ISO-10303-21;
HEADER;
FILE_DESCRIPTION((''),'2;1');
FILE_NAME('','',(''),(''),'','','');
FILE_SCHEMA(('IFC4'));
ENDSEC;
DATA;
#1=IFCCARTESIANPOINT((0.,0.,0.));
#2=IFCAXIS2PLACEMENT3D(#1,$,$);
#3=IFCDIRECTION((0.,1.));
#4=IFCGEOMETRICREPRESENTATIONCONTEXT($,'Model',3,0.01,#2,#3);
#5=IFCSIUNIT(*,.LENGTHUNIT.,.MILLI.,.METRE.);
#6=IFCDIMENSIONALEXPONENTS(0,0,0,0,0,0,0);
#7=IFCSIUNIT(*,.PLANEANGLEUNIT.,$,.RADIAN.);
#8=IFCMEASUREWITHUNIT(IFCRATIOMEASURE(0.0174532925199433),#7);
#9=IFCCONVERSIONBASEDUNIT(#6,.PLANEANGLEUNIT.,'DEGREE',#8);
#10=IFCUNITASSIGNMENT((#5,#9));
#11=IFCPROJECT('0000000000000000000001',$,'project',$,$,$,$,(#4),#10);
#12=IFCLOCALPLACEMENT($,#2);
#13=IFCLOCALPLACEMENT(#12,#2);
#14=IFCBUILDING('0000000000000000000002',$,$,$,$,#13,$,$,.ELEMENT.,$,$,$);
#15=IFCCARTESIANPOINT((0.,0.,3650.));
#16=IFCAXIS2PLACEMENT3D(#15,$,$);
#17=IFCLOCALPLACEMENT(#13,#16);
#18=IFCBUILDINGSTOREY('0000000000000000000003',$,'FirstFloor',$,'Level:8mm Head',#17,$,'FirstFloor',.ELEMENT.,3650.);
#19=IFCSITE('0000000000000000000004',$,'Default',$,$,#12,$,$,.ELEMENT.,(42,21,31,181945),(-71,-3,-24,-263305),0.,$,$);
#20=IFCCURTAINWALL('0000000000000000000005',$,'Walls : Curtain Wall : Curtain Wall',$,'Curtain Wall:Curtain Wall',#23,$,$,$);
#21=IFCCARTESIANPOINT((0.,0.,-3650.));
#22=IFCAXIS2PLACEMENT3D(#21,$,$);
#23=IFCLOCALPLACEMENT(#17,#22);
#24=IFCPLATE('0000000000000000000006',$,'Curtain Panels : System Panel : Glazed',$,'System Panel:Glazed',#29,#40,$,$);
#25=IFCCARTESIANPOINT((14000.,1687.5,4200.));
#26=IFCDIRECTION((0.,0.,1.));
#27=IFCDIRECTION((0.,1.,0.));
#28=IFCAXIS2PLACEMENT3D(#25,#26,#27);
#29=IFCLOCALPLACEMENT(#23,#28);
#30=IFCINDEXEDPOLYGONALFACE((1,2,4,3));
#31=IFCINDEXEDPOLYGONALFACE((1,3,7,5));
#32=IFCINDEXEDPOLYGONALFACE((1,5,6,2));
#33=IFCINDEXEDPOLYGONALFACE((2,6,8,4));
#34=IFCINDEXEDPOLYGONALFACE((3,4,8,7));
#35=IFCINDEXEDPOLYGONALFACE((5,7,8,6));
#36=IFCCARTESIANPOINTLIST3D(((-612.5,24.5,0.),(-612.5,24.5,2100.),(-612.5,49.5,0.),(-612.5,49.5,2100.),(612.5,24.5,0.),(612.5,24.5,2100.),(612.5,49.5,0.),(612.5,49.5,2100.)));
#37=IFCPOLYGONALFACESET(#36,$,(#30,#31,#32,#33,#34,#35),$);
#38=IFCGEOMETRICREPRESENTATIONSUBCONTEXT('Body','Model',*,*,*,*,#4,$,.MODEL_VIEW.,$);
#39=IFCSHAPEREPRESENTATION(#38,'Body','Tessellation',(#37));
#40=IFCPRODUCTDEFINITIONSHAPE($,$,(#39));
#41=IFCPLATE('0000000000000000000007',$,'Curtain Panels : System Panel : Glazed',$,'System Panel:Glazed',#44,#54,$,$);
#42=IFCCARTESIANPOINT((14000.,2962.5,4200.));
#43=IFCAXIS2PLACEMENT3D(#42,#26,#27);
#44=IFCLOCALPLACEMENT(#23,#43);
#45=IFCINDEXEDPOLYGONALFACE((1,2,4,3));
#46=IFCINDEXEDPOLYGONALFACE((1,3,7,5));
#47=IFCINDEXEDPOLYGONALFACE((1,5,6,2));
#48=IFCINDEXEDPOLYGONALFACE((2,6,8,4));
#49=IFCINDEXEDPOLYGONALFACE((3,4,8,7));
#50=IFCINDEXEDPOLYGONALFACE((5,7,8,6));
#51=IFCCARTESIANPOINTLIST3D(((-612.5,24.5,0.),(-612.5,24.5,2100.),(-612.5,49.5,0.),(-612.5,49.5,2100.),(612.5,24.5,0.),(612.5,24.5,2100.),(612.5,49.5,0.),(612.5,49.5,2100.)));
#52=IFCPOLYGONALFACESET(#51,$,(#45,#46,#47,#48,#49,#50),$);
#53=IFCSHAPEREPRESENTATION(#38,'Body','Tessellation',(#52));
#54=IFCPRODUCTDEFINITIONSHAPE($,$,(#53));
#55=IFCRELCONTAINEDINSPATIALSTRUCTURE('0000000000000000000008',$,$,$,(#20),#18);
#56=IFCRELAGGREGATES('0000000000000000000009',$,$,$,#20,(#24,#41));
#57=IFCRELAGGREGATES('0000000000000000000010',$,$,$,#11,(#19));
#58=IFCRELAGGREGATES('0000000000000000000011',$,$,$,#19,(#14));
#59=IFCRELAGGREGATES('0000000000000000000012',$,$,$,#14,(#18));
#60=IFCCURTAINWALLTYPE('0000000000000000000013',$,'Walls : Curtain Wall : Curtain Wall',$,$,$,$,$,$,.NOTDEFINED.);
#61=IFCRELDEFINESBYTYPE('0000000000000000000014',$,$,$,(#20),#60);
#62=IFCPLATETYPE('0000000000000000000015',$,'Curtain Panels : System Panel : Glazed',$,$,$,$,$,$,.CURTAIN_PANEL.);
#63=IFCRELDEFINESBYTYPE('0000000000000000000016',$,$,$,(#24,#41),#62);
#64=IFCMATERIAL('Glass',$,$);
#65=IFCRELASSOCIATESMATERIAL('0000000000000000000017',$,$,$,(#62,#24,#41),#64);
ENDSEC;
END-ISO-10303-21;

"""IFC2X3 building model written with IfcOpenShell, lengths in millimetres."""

from ifc_helpers import new_model, entity, si_unit, converted_unit, direction, frame, origin, origin_2d_with_axis, place, context, subcontext, project, spatial, rectangle, extrude, source, transform, mapped, material, type_object, type_shapes, element, aggregate, save


model = new_model("IFC2X3")

# Units and contexts
model_context = context("Model", 3, precision=0.01, world=origin(), true_north=direction((0.0, 1.0)))
body_context = subcontext(model_context, "Body", "Model", "MODEL_VIEW")
ifc_project = project(units=[si_unit("LENGTHUNIT", "METRE", prefix="MILLI"), converted_unit("PLANEANGLEUNIT", "DEGREE", entity("IfcRatioMeasure", 0.0174532925199433), si_unit("PLANEANGLEUNIT", "RADIAN"), dimensions=[0, 0, 0, 0, 0, 0, 0])], contexts=[model_context])

# Site, building, storey
site_placement = place(None, origin())
site = spatial("IfcSite", under=ifc_project, at=site_placement, Name="Default", CompositionType="ELEMENT", RefLatitude=(42, 21, 31, 181945), RefLongitude=(-71, -3, -24, -263305), RefElevation=0.0)
building_placement = place(site_placement, origin())
building = spatial("IfcBuilding", under=site, at=building_placement, CompositionType="ELEMENT")
storey_placement = place(building_placement, frame((0.0, 0.0, 3650.0)))
storey = spatial("IfcBuildingStorey", under=building, at=storey_placement, Name="FirstFloor", ObjectType="Level:8mm Head", LongName="FirstFloor", CompositionType="ELEMENT", Elevation=3650.0)

# Curtain wall, plates
curtain_wall_type = type_object("IfcCurtainWallType", Name="Walls : Curtain Wall : Curtain Wall", PredefinedType="NOTDEFINED")
curtain_wall_placement = place(storey_placement, frame((0.0, 0.0, -3650.0)))
curtain_wall = element("IfcCurtainWall", 1, at=curtain_wall_placement, inside=storey, type_object=curtain_wall_type, Name="Walls : Curtain Wall : Curtain Wall", ObjectType="Curtain Wall:Curtain Wall")
ifc_material_1 = material(Name="Glass")
plate_type = type_object("IfcPlateType", Name="Curtain Panels : System Panel : Glazed", PredefinedType="CURTAIN_PANEL", material=ifc_material_1)
shared_shape_1 = source(origin(), body_context, "Body", "SweptSolid", [
    extrude(rectangle(XDim=25.0, YDim=1225.0, at=origin_2d_with_axis()), frame((0.0, 37.0, 0.0), z_axis=(0.0, 0.0, 1.0), x_axis=(0.0, 1.0, 0.0)), (0.0, 0.0, 1.0), 2100.0),
])
type_shapes(plate_type, [shared_shape_1])
plate_1_placement = place(curtain_wall_placement, frame((14000.0, 1687.5, 4200.0), z_axis=(0.0, 0.0, 1.0), x_axis=(0.0, 1.0, 0.0)))
plate_1 = element("IfcPlate", 2, at=plate_1_placement, type_object=plate_type, material=ifc_material_1, Name="Curtain Panels : System Panel : Glazed", ObjectType="System Panel:Glazed", context=body_context, shape_type="MappedRepresentation", body=[
    mapped(shared_shape_1, transform((0.0, 0.0, 0.0), scale=1.0)),
])
plate_2_placement = place(curtain_wall_placement, frame((14000.0, 2962.5, 4200.0), z_axis=(0.0, 0.0, 1.0), x_axis=(0.0, 1.0, 0.0)))
plate_2 = element("IfcPlate", 3, at=plate_2_placement, type_object=plate_type, material=ifc_material_1, Name="Curtain Panels : System Panel : Glazed", ObjectType="System Panel:Glazed", context=body_context, shape_type="MappedRepresentation", body=[
    mapped(shared_shape_1, transform((0.0, 0.0, 0.0), scale=1.0)),
])
aggregate(curtain_wall, [plate_1, plate_2])

save(model, "model.ifc")
